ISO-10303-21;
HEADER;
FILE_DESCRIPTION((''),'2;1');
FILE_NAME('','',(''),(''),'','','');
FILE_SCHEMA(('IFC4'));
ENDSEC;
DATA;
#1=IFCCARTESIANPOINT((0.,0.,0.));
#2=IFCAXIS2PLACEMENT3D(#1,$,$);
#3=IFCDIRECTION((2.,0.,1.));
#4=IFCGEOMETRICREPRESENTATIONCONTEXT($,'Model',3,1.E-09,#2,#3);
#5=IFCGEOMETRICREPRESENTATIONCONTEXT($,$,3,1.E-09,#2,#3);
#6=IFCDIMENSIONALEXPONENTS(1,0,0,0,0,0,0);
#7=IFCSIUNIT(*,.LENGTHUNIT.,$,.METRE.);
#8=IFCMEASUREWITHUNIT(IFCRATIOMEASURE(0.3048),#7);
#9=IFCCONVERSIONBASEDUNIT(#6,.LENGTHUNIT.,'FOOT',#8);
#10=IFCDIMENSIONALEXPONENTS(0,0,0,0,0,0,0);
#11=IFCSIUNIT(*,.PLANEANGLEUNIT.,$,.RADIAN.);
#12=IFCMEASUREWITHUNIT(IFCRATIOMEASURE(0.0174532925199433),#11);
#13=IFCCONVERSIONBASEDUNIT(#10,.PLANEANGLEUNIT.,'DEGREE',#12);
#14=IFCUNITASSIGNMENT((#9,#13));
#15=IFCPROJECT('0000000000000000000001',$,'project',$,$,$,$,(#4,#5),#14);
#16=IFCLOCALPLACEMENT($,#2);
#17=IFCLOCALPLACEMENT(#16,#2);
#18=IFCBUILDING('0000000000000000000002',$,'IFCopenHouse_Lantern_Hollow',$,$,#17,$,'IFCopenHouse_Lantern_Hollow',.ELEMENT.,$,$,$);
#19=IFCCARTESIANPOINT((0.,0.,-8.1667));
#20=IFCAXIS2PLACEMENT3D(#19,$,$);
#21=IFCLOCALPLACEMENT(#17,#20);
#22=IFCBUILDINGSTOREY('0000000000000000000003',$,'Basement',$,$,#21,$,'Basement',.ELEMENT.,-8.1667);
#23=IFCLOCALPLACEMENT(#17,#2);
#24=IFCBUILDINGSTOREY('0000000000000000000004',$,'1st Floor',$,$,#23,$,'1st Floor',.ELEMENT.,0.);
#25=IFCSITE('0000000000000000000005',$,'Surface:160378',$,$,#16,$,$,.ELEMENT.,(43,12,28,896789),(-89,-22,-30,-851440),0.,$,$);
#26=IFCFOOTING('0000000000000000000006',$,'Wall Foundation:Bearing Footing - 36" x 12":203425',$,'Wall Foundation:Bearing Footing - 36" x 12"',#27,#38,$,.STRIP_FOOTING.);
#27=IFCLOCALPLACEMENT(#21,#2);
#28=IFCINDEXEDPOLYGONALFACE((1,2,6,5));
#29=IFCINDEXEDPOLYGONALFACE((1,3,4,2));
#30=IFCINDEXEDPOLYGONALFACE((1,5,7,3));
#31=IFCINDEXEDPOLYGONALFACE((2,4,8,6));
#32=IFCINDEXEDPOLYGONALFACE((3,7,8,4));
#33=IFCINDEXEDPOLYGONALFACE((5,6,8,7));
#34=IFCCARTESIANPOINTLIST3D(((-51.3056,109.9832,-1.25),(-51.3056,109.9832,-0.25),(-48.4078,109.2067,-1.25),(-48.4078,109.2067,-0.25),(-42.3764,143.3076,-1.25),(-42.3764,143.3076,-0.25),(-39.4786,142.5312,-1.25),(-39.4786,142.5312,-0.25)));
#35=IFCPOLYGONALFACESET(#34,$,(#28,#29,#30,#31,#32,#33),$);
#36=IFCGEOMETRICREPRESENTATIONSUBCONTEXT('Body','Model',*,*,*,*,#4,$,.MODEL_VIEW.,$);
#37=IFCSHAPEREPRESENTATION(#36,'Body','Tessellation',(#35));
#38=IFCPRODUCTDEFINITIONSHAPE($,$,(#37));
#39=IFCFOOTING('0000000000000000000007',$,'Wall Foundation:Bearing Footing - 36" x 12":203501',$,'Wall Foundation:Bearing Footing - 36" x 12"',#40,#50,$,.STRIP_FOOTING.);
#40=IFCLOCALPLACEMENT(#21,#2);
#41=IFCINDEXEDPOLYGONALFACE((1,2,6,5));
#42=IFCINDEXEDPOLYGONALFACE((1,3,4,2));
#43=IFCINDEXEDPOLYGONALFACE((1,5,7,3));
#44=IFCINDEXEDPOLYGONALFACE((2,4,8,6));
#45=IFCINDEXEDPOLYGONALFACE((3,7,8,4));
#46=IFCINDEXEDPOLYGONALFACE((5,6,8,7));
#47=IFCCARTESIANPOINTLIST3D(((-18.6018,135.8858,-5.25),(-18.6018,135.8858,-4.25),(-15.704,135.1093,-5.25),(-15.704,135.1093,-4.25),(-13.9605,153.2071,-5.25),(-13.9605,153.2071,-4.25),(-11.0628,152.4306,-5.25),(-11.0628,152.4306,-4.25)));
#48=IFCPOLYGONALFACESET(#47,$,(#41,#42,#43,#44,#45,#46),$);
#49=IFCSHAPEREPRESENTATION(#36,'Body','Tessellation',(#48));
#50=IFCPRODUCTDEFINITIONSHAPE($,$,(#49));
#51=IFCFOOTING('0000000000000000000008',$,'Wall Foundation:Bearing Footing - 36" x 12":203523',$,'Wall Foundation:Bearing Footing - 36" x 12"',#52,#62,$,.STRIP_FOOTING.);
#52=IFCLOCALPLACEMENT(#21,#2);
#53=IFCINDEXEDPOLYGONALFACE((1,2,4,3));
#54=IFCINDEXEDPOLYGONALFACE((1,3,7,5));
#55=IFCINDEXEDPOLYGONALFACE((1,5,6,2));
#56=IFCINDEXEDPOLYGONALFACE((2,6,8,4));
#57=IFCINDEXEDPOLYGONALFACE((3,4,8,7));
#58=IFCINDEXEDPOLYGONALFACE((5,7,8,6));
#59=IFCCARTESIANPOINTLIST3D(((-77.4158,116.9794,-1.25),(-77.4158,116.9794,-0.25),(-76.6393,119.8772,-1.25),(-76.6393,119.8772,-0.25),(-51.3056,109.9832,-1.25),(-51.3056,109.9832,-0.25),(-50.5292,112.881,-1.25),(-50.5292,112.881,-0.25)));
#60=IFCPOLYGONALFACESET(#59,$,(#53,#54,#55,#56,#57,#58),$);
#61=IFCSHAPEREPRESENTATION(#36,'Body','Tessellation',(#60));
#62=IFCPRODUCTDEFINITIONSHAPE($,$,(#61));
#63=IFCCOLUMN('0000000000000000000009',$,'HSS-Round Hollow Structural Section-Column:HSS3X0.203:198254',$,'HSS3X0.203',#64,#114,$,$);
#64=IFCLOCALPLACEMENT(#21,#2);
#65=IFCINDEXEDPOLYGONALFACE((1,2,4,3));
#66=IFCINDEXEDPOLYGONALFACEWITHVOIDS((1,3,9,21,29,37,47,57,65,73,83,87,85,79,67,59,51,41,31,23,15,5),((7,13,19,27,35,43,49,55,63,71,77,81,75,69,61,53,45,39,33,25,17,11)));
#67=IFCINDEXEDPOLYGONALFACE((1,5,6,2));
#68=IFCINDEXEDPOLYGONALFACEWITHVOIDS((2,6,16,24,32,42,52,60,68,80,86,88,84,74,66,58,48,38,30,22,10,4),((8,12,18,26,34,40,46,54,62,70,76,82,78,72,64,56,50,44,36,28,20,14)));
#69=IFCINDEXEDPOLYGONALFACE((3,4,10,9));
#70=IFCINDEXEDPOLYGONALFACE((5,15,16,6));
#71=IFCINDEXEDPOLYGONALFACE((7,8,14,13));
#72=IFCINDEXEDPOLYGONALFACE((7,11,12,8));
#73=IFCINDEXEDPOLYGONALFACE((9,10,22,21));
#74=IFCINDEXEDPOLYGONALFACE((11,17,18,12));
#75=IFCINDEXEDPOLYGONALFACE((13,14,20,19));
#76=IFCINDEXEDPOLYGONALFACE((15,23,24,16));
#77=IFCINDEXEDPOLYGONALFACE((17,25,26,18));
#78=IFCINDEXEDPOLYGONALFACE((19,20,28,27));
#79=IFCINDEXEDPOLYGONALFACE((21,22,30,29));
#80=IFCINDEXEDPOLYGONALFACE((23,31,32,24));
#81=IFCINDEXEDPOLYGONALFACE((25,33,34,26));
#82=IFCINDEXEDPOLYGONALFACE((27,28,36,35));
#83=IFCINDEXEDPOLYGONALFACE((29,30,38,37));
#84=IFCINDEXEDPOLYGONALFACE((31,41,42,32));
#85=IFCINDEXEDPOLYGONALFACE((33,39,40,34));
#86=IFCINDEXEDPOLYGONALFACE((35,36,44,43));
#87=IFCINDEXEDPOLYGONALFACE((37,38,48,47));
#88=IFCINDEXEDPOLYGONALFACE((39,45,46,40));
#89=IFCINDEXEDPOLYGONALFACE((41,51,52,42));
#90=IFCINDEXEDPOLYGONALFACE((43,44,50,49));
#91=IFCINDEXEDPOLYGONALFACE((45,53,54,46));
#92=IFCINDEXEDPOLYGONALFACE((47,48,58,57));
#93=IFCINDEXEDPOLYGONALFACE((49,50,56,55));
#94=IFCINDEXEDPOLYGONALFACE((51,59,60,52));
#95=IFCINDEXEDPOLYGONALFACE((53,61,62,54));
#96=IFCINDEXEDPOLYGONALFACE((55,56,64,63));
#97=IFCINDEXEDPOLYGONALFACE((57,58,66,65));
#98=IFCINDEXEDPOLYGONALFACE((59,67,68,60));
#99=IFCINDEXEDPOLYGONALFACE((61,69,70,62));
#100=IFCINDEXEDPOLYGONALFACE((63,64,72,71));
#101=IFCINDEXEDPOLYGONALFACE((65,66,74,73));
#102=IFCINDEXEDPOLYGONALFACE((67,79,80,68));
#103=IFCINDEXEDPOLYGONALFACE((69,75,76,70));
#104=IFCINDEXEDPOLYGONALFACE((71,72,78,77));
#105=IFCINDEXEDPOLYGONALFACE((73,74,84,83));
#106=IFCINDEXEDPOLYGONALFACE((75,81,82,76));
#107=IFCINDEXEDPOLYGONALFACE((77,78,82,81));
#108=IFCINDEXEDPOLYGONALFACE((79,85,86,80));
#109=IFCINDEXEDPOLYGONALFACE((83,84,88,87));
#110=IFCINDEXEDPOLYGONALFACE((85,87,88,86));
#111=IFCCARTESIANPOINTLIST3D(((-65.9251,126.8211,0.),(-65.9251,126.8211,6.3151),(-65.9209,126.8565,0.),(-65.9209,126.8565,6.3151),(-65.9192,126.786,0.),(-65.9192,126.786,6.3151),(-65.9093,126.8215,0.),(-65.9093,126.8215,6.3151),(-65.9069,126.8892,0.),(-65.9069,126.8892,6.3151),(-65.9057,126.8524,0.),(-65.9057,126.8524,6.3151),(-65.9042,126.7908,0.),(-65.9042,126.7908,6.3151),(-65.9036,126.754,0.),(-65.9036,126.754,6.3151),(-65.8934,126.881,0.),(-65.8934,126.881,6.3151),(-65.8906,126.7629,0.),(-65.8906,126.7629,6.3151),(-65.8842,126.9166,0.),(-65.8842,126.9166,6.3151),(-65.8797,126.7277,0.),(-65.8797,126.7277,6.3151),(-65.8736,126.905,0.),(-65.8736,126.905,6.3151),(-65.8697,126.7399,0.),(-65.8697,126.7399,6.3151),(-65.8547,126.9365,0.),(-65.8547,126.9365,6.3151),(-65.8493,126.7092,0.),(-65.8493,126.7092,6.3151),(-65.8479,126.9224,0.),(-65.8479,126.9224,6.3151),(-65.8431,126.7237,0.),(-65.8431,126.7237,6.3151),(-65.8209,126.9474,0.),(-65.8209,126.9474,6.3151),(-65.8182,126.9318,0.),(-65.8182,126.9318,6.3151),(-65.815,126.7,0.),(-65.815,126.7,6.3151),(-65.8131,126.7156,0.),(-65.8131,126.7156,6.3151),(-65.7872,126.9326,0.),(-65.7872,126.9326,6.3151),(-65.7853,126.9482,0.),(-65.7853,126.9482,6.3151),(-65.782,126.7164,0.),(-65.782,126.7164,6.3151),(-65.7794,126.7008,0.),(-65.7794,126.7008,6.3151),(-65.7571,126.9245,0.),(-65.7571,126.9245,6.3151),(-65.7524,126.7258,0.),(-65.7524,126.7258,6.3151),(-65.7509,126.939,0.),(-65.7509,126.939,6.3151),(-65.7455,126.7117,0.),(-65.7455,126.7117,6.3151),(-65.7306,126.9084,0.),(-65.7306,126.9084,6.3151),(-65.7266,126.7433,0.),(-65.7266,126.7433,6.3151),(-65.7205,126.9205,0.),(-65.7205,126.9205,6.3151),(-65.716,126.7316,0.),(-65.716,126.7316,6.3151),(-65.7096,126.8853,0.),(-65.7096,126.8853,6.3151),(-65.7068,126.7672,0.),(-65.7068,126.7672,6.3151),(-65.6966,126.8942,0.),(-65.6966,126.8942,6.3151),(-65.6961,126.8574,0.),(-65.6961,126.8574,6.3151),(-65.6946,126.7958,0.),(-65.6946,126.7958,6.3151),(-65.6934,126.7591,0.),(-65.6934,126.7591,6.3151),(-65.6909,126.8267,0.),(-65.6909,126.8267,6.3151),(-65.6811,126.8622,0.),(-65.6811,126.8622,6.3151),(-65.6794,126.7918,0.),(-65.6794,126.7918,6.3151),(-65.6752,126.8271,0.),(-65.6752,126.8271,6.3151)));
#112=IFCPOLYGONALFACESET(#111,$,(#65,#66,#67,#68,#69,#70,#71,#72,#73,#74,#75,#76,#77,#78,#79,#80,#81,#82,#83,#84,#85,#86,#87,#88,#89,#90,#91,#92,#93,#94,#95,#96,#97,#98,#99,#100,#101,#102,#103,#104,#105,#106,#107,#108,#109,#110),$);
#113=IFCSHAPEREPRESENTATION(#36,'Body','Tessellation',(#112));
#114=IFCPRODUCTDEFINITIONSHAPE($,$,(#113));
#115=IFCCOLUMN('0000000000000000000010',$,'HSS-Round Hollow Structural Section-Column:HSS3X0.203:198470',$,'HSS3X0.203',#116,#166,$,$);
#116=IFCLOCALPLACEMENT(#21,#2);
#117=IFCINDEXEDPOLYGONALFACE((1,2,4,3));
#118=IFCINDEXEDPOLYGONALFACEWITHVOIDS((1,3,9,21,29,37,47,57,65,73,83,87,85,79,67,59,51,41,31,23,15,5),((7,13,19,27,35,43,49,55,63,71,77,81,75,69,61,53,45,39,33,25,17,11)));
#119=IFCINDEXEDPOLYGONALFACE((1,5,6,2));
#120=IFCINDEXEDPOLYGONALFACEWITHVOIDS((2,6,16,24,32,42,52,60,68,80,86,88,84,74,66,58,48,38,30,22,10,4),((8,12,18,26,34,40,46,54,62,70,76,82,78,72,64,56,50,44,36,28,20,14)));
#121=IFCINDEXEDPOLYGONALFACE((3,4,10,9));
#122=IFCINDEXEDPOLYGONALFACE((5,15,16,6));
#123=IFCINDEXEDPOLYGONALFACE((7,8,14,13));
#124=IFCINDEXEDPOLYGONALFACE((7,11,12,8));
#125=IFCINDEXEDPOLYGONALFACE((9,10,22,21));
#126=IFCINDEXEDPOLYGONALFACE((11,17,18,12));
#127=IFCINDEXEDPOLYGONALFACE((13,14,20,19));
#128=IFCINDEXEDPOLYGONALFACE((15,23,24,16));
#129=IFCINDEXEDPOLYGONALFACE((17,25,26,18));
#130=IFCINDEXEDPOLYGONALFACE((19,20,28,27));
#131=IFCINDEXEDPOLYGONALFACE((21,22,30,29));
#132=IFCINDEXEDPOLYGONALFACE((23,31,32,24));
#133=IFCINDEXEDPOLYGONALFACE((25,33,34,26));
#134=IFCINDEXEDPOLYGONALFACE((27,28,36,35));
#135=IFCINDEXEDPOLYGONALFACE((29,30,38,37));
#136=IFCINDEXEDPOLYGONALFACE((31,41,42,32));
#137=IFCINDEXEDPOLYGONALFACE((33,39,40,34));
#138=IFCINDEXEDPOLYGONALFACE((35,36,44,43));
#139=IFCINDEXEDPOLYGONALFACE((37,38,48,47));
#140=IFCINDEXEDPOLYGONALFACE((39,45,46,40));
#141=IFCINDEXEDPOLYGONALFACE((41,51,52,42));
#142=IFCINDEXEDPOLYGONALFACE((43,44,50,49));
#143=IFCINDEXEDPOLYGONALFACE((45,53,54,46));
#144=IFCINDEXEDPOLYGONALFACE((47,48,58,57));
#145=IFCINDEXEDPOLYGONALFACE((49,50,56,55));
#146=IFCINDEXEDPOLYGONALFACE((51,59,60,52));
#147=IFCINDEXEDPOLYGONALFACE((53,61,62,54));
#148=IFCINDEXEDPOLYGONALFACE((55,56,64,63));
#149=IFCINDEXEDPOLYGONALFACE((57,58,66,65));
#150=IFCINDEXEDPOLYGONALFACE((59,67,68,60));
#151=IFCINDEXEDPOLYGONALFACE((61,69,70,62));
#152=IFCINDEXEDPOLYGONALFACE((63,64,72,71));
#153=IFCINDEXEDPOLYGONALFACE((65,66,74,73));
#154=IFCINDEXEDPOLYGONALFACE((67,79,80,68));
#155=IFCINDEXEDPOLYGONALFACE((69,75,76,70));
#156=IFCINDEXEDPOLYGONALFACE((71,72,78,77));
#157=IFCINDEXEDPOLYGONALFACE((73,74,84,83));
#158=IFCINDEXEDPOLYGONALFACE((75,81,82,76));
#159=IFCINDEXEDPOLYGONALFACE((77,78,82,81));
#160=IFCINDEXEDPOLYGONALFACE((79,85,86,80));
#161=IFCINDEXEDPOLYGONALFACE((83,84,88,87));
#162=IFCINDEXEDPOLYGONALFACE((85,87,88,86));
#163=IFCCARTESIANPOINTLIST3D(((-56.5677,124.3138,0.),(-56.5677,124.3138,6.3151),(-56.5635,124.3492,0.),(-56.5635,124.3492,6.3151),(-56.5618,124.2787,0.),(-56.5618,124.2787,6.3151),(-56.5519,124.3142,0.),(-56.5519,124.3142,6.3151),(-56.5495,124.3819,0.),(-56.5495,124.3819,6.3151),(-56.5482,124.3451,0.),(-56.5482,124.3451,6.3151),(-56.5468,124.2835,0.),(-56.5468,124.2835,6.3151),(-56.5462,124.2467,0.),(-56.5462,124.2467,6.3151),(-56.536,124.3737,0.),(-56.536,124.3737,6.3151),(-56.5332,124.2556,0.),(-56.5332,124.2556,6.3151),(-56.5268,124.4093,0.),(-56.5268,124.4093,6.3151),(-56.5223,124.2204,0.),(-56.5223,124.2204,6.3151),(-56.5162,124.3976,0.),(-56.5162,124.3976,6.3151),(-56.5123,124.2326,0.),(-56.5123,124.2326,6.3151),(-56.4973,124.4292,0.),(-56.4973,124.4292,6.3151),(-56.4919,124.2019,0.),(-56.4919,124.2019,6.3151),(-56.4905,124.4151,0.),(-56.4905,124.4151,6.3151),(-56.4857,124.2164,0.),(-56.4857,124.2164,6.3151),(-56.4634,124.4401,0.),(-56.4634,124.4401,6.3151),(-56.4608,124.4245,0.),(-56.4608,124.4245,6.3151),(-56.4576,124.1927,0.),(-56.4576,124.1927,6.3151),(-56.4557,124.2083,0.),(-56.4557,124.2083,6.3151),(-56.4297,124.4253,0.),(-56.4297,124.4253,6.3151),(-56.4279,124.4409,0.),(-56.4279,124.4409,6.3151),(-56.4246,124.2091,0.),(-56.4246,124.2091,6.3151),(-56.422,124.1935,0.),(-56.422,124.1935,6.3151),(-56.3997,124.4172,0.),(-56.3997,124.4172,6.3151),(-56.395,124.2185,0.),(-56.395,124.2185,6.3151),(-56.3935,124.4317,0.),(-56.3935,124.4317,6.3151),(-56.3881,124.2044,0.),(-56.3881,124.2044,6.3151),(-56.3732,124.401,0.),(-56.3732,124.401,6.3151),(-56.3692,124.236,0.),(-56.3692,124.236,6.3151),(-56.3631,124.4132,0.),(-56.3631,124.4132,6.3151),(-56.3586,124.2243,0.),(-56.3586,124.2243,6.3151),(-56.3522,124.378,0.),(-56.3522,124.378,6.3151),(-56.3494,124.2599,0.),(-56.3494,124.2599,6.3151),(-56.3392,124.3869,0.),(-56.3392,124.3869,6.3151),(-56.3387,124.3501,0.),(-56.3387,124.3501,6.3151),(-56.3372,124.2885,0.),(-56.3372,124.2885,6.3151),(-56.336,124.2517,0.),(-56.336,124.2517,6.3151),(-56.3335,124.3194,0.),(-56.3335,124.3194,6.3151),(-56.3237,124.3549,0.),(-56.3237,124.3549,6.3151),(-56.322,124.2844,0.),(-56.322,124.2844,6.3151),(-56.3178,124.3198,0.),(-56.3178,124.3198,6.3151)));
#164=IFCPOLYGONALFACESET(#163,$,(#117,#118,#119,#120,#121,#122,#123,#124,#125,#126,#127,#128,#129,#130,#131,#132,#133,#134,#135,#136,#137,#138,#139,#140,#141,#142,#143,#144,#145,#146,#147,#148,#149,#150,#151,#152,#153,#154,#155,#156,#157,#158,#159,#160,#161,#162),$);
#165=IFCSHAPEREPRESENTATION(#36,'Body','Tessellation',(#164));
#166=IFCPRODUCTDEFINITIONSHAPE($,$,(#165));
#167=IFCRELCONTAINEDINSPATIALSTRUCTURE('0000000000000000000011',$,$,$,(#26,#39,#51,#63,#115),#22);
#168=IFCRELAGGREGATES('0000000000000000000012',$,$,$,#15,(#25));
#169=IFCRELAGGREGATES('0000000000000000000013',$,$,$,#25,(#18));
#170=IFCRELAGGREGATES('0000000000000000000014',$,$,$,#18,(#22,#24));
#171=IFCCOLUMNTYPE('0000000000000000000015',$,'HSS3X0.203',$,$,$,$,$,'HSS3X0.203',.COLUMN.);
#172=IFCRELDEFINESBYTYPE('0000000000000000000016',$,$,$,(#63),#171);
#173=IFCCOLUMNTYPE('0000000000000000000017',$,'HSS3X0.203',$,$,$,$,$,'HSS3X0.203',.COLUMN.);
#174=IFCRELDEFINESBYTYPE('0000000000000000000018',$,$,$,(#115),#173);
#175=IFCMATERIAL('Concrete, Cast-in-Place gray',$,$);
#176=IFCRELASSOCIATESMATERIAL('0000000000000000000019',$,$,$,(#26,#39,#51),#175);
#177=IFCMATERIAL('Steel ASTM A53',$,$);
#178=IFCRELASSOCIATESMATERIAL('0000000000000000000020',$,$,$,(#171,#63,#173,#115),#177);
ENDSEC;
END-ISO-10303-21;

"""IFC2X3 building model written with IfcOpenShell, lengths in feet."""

from ifc_helpers import new_model, entity, si_unit, converted_unit, direction, frame, frame_2d, origin, place, context, subcontext, project, spatial, circle_curve, parameter, trimmed, segment, composite_curve, rectangle, outline, extrude, source, transform, mapped, material, type_object, type_shapes, element, save


model = new_model("IFC2X3")

# Units and contexts
model_context = context("Model", 3, precision=1e-09, world=origin(), true_north=direction((2.0, 0.0, 1.0)))
context_of_model = context(None, 3, precision=1e-09, world=origin(), true_north=direction((2.0, 0.0, 1.0)))
body_context = subcontext(model_context, "Body", "Model", "MODEL_VIEW")
ifc_project = project(units=[converted_unit("LENGTHUNIT", "FOOT", entity("IfcRatioMeasure", 0.3048), si_unit("LENGTHUNIT", "METRE"), dimensions=[1, 0, 0, 0, 0, 0, 0]), converted_unit("PLANEANGLEUNIT", "DEGREE", entity("IfcRatioMeasure", 0.0174532925199433), si_unit("PLANEANGLEUNIT", "RADIAN"), dimensions=[0, 0, 0, 0, 0, 0, 0])], contexts=[model_context, context_of_model])

# Site, building, storey
site_placement = place(None, origin())
site = spatial("IfcSite", under=ifc_project, at=site_placement, Name="Surface:160378", CompositionType="ELEMENT", RefLatitude=(43, 12, 28, 896789), RefLongitude=(-89, -22, -30, -851440), RefElevation=0.0)
building_placement = place(site_placement, origin())
building = spatial("IfcBuilding", under=site, at=building_placement, Name="IFCopenHouse_Lantern_Hollow", LongName="IFCopenHouse_Lantern_Hollow", CompositionType="ELEMENT")
storey_1_placement = place(building_placement, frame((0.0, 0.0, -8.1667)))
storey_1 = spatial("IfcBuildingStorey", under=building, at=storey_1_placement, Name="Basement", LongName="Basement", CompositionType="ELEMENT", Elevation=-8.1667)

# Footings
ifc_material_1 = material(Name="Concrete, Cast-in-Place gray")
footing_1_placement = place(storey_1_placement, origin())
element("IfcFooting", 1, at=footing_1_placement, inside=storey_1, material=ifc_material_1, Name="Wall Foundation:Bearing Footing - 36\" x 12\":203425", ObjectType="Wall Foundation:Bearing Footing - 36\" x 12\"", PredefinedType="STRIP_FOOTING", context=body_context, shape_type="SweptSolid", body=[
    extrude(rectangle(XDim=34.5, YDim=3.0, at=frame_2d((0.0, 0.0), x_axis=(1.0, 0.0))), frame((-45.3921, 126.2572, -1.25), z_axis=(0.0, 0.0, 1.0), x_axis=(-0.258819, -0.965926, 0.0)), (0.0, 0.0, 1.0), 1.0),
])
footing_2_placement = place(storey_1_placement, origin())
element("IfcFooting", 2, at=footing_2_placement, inside=storey_1, material=ifc_material_1, Name="Wall Foundation:Bearing Footing - 36\" x 12\":203501", ObjectType="Wall Foundation:Bearing Footing - 36\" x 12\"", PredefinedType="STRIP_FOOTING", context=body_context, shape_type="SweptSolid", body=[
    extrude(rectangle(XDim=17.9323, YDim=3.0, at=frame_2d((0.0, 0.0), x_axis=(1.0, 0.0))), frame((-14.8323, 144.1582, -5.25), z_axis=(0.0, 0.0, 1.0), x_axis=(0.258819, 0.965926, 0.0)), (0.0, 0.0, 1.0), 1.0),
])
footing_3_placement = place(storey_1_placement, origin())
element("IfcFooting", 3, at=footing_3_placement, inside=storey_1, material=ifc_material_1, Name="Wall Foundation:Bearing Footing - 36\" x 12\":203523", ObjectType="Wall Foundation:Bearing Footing - 36\" x 12\"", PredefinedType="STRIP_FOOTING", context=body_context, shape_type="SweptSolid", body=[
    extrude(rectangle(XDim=27.0313, YDim=3.0, at=frame_2d((0.0, 0.0), x_axis=(1.0, 0.0))), frame((-63.9725, 114.9302, -1.25), z_axis=(0.0, 0.0, 1.0), x_axis=(0.965926, -0.258819, 0.0)), (0.0, 0.0, 1.0), 1.0),
])

# Columns
ifc_material_2 = material(Name="Steel ASTM A53")
column_type_1 = type_object("IfcColumnType", Name="HSS3X0.203", ElementType="HSS3X0.203", PredefinedType="COLUMN", material=ifc_material_2)
shared_shape_1 = source(origin(), body_context, "Body", "SweptSolid", [
    extrude(outline(composite_curve([segment(trimmed(circle_curve(frame_2d((-65.8001, 126.8241), x_axis=(0.965926, -0.258819)), 0.125), [parameter(0.0)], [parameter(180.0)], True, "PARAMETER"), True, "CONTINUOUS"), segment(trimmed(circle_curve(frame_2d((-65.8001, 126.8241), x_axis=(0.965926, -0.258819)), 0.125), [parameter(180.0)], [parameter(0.0)], True, "PARAMETER"), True, "CONTINUOUS")], self_intersect=False), holes=[composite_curve([segment(trimmed(circle_curve(frame_2d((-65.8001, 126.8241), x_axis=(0.965926, -0.258819)), 0.1092), [parameter(180.0)], [parameter(0.0)], True, "PARAMETER"), False, "CONTINUOUS"), segment(trimmed(circle_curve(frame_2d((-65.8001, 126.8241), x_axis=(0.965926, -0.258819)), 0.1092), [parameter(0.0)], [parameter(180.0)], True, "PARAMETER"), False, "CONTINUOUS")], self_intersect=False)]), origin(), (0.0, 0.0, 1.0), 6.3151),
])
type_shapes(column_type_1, [shared_shape_1])
column_1_placement = place(storey_1_placement, origin())
element("IfcColumn", 4, at=column_1_placement, inside=storey_1, type_object=column_type_1, material=ifc_material_2, Name="HSS-Round Hollow Structural Section-Column:HSS3X0.203:198254", ObjectType="HSS3X0.203", context=body_context, shape_type="MappedRepresentation", body=[
    mapped(shared_shape_1, transform((0.0, 0.0, 0.0), scale=1.0)),
])
column_type_2 = type_object("IfcColumnType", Name="HSS3X0.203", ElementType="HSS3X0.203", PredefinedType="COLUMN", material=ifc_material_2)
shared_shape_2 = source(origin(), body_context, "Body", "SweptSolid", [
    extrude(outline(composite_curve([segment(trimmed(circle_curve(frame_2d((-56.4427, 124.3168), x_axis=(0.965926, -0.258819)), 0.125), [parameter(0.0)], [parameter(180.0)], True, "PARAMETER"), True, "CONTINUOUS"), segment(trimmed(circle_curve(frame_2d((-56.4427, 124.3168), x_axis=(0.965926, -0.258819)), 0.125), [parameter(180.0)], [parameter(0.0)], True, "PARAMETER"), True, "CONTINUOUS")], self_intersect=False), holes=[composite_curve([segment(trimmed(circle_curve(frame_2d((-56.4427, 124.3168), x_axis=(0.965926, -0.258819)), 0.1092), [parameter(180.0)], [parameter(0.0)], True, "PARAMETER"), False, "CONTINUOUS"), segment(trimmed(circle_curve(frame_2d((-56.4427, 124.3168), x_axis=(0.965926, -0.258819)), 0.1092), [parameter(0.0)], [parameter(180.0)], True, "PARAMETER"), False, "CONTINUOUS")], self_intersect=False)]), origin(), (0.0, 0.0, 1.0), 6.3151),
])
type_shapes(column_type_2, [shared_shape_2])
column_2_placement = place(storey_1_placement, origin())
element("IfcColumn", 5, at=column_2_placement, inside=storey_1, type_object=column_type_2, material=ifc_material_2, Name="HSS-Round Hollow Structural Section-Column:HSS3X0.203:198470", ObjectType="HSS3X0.203", context=body_context, shape_type="MappedRepresentation", body=[
    mapped(shared_shape_2, transform((0.0, 0.0, 0.0), scale=1.0)),
])

# Shared definitions
storey_2_placement = place(building_placement, origin())
storey_2 = spatial("IfcBuildingStorey", under=building, at=storey_2_placement, Name="1st Floor", LongName="1st Floor", CompositionType="ELEMENT", Elevation=0.0)

save(model, "model.ifc")
